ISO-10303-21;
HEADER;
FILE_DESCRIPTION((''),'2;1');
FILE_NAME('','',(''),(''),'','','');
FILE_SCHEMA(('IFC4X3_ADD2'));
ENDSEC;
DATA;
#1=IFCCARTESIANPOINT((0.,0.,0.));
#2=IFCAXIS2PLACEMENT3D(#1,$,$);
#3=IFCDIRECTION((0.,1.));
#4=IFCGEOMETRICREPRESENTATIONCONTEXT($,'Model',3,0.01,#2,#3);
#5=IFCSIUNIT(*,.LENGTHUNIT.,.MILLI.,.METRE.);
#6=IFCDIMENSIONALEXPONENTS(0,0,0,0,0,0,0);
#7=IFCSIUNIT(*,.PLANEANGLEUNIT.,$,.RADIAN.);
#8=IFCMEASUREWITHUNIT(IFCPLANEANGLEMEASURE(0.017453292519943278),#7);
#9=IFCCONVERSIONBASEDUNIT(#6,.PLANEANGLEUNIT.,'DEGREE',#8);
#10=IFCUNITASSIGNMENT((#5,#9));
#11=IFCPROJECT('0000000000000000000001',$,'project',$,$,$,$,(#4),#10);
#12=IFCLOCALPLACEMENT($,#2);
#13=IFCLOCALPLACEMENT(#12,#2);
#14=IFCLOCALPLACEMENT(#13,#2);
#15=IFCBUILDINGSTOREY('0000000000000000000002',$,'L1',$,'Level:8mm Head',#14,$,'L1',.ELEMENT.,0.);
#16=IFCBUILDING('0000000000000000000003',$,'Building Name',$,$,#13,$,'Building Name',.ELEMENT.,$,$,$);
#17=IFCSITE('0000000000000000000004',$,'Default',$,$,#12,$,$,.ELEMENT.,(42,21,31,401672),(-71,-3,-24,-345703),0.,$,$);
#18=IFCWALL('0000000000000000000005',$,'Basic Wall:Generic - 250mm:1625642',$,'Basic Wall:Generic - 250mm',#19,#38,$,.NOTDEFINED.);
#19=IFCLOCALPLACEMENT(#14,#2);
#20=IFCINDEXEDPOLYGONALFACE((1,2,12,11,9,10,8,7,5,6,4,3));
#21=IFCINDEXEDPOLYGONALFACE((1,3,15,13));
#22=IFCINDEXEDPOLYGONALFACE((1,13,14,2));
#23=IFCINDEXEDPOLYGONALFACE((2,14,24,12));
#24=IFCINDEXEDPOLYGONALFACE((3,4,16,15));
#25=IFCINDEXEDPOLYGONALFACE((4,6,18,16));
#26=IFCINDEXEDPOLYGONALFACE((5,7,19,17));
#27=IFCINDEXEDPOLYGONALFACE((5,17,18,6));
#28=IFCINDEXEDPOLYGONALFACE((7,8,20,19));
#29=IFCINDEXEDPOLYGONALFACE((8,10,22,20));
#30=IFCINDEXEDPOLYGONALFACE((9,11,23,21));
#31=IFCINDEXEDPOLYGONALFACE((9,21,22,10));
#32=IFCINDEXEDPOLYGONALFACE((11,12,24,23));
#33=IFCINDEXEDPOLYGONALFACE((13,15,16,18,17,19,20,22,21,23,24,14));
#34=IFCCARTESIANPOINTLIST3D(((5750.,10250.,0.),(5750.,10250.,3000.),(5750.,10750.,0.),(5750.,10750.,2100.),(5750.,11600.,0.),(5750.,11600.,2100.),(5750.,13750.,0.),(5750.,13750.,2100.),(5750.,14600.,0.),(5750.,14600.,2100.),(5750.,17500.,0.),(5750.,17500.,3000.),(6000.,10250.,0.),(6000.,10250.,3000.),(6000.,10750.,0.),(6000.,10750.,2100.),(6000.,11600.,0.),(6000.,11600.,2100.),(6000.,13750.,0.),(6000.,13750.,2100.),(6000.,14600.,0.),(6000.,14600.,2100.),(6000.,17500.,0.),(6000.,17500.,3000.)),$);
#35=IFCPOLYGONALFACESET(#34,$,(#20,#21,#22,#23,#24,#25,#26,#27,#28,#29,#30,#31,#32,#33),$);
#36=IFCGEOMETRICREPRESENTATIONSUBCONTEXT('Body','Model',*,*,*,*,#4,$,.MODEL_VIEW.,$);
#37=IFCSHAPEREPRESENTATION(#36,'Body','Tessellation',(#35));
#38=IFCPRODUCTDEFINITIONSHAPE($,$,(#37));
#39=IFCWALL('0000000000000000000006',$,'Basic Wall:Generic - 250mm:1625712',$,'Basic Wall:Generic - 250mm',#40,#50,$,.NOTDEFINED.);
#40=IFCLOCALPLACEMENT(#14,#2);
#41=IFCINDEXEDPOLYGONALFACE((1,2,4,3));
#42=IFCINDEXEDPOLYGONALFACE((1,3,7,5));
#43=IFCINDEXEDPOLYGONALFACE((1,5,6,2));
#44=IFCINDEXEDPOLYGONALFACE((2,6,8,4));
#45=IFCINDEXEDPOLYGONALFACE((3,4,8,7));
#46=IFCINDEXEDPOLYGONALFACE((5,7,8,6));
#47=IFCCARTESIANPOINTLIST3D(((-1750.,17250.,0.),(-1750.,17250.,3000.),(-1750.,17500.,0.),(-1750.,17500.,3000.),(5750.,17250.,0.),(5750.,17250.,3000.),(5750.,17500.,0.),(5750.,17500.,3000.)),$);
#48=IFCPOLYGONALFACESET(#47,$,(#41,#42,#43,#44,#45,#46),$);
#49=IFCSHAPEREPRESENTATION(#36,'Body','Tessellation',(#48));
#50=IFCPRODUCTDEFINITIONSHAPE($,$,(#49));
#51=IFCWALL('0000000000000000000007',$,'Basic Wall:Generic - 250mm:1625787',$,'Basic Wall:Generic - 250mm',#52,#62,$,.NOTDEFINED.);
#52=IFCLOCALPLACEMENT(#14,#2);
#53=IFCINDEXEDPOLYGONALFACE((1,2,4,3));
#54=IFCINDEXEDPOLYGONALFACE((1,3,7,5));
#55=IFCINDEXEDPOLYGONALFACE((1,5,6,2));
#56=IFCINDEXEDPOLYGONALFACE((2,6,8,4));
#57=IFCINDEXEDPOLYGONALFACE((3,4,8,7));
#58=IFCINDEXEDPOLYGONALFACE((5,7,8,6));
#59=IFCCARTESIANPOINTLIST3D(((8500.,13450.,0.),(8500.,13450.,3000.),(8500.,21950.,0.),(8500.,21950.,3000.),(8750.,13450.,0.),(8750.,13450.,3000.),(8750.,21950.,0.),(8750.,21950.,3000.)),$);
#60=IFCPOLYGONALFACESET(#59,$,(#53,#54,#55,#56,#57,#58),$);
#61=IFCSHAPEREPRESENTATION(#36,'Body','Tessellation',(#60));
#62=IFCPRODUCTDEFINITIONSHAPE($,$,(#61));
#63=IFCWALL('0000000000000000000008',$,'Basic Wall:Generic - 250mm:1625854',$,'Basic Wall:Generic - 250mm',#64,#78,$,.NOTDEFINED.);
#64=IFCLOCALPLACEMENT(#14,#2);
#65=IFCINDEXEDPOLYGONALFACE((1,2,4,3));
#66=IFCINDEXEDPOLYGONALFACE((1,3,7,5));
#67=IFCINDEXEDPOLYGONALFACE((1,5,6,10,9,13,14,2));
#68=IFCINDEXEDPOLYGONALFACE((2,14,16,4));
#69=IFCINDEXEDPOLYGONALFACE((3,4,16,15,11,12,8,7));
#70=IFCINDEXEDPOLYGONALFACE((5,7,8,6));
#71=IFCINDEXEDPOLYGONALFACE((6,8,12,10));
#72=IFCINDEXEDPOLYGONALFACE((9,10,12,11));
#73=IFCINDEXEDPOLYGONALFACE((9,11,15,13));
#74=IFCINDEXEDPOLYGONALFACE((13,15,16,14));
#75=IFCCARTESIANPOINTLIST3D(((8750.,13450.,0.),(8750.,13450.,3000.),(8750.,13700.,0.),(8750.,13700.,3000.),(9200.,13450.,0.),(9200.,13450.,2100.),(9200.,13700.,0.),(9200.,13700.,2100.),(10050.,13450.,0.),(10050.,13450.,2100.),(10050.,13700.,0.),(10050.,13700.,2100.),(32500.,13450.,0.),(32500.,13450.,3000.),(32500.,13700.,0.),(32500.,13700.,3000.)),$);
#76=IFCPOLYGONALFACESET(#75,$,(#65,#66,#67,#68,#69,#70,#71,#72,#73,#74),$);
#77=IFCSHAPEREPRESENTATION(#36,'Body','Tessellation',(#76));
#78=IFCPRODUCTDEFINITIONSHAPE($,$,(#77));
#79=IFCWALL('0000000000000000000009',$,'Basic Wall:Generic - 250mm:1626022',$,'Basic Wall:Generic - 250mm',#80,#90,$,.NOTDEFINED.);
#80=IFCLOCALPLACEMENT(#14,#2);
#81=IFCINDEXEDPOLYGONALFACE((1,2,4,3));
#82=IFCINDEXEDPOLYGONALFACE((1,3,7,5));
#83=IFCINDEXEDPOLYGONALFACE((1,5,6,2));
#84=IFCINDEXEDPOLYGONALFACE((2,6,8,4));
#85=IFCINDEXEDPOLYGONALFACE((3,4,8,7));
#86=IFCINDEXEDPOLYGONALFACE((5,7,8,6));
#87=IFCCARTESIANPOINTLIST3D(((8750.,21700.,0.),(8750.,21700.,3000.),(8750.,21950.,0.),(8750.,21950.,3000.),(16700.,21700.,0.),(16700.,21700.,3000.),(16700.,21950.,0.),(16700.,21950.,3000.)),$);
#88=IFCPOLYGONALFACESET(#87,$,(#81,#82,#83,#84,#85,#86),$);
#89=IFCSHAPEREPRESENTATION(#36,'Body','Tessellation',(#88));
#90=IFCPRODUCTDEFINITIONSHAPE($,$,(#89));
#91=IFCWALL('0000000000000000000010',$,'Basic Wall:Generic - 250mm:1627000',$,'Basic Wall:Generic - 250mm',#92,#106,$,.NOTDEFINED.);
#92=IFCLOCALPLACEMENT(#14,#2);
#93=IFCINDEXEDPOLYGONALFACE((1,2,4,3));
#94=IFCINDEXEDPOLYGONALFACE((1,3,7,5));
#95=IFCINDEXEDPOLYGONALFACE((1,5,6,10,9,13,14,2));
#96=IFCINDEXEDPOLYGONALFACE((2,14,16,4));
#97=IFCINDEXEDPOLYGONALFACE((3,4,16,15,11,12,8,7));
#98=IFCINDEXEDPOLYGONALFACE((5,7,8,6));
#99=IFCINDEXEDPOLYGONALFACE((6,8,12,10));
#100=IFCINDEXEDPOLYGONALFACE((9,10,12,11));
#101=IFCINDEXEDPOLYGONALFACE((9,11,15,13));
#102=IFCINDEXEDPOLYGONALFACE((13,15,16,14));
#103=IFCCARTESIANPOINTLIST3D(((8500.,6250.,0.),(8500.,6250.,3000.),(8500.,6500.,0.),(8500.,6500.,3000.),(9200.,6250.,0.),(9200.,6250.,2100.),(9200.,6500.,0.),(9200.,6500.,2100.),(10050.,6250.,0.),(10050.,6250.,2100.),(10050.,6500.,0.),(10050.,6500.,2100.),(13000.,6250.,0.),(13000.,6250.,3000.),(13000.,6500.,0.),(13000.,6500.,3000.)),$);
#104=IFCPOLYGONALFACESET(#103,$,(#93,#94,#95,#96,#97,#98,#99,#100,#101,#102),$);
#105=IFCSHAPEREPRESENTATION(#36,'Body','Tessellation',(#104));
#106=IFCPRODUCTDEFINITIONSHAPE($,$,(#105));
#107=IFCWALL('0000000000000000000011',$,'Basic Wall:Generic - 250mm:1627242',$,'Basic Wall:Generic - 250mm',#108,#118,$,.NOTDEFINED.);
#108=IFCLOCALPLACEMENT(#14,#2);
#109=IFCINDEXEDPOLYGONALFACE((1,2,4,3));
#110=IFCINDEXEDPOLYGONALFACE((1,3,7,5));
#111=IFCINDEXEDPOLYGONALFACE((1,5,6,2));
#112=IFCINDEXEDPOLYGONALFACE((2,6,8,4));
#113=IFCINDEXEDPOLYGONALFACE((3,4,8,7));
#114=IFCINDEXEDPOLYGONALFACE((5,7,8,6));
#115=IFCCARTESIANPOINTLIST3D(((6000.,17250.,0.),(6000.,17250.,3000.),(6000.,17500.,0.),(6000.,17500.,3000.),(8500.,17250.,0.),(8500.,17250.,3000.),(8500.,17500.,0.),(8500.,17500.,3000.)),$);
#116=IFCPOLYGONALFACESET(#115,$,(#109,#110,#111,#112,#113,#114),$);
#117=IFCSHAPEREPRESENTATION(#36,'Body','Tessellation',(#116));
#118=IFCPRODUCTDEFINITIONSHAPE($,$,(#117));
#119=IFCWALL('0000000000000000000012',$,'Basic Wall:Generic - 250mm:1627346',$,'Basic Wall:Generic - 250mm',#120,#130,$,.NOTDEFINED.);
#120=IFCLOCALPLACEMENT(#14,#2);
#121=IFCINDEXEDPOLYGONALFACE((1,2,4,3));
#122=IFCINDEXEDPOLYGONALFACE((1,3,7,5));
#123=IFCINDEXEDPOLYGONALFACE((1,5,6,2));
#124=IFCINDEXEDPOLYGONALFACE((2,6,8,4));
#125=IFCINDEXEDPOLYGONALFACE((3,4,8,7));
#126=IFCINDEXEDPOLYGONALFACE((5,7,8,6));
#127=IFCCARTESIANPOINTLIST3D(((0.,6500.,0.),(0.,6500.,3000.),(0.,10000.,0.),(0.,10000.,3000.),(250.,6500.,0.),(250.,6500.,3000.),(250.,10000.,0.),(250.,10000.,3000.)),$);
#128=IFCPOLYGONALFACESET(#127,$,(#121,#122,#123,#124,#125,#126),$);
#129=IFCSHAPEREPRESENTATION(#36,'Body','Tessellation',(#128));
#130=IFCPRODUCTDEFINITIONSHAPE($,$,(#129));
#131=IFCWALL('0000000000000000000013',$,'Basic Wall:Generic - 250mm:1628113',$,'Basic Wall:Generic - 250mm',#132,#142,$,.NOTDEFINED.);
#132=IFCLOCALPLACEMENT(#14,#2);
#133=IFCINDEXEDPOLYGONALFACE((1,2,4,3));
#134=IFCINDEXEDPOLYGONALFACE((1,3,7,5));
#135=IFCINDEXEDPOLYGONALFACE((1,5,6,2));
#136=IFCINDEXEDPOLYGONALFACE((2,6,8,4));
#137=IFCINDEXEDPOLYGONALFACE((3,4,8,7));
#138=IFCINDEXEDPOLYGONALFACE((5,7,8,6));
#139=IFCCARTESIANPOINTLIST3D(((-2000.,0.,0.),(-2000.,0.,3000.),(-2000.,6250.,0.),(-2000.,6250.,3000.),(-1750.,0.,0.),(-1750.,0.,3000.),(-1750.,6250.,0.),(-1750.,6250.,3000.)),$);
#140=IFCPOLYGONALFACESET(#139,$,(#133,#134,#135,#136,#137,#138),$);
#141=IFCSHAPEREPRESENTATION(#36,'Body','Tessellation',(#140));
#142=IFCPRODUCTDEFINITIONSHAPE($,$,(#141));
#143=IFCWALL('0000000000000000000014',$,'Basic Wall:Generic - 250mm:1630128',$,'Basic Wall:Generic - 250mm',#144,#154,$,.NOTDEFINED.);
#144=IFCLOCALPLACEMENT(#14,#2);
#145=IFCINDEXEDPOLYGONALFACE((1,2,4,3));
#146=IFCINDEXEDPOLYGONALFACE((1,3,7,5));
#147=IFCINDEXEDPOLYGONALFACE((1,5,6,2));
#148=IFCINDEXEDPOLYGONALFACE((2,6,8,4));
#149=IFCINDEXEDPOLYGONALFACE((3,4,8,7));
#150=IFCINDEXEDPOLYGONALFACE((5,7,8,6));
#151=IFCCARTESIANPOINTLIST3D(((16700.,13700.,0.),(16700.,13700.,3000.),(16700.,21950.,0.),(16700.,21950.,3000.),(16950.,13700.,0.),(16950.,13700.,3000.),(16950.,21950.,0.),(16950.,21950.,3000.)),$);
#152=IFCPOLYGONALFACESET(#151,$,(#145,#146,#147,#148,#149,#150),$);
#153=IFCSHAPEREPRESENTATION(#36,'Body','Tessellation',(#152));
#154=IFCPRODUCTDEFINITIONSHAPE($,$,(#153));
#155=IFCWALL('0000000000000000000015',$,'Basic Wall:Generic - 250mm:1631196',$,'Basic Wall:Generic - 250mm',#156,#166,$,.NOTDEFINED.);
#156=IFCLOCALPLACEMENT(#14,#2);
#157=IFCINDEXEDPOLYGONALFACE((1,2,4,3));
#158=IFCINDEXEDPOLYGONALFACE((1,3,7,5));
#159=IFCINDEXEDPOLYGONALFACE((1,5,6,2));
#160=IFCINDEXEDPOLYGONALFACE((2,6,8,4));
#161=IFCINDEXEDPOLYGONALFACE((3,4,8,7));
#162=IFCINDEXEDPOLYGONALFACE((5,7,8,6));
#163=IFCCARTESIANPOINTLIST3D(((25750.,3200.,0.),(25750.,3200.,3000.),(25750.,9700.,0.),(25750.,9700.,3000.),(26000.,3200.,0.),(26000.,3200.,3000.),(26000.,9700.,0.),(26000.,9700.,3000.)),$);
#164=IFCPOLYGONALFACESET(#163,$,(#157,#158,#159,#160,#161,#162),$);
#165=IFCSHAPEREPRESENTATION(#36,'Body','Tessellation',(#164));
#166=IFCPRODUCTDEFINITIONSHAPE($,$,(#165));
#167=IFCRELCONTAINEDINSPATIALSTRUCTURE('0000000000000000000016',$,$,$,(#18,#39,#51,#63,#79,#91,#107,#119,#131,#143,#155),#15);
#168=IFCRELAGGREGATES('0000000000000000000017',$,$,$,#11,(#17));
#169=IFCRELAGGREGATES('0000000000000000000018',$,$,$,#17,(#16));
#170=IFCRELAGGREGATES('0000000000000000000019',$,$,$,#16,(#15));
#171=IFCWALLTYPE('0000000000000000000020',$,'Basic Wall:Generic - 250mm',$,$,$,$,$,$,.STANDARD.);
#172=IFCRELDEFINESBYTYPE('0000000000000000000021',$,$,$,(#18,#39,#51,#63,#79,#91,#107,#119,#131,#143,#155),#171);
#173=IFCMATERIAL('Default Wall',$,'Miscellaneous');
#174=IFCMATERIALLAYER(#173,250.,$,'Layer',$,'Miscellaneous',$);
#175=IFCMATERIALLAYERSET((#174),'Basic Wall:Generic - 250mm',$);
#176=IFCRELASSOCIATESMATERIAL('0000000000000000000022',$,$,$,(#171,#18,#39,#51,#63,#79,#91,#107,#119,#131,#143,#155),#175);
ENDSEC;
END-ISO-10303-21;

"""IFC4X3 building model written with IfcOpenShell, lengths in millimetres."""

from ifc_helpers import new_model, entity, si_unit, converted_unit, direction, frame, frame_2d, origin, place, context, subcontext, project, spatial, rectangle, extrude, material, layer, layer_set, type_object, element, save


model = new_model("IFC4X3")

# Units and contexts
model_context = context("Model", 3, precision=0.01, world=origin(), true_north=direction((0.0, 1.0)))
body_context = subcontext(model_context, "Body", "Model", "MODEL_VIEW")
ifc_project = project(units=[si_unit("LENGTHUNIT", "METRE", prefix="MILLI"), converted_unit("PLANEANGLEUNIT", "DEGREE", entity("IfcPlaneAngleMeasure", 0.017453292519943278), si_unit("PLANEANGLEUNIT", "RADIAN"), dimensions=[0, 0, 0, 0, 0, 0, 0])], contexts=[model_context])

# Site, building, storey
site_placement = place(None, origin())
site = spatial("IfcSite", under=ifc_project, at=site_placement, Name="Default", CompositionType="ELEMENT", RefLatitude=(42, 21, 31, 401672), RefLongitude=(-71, -3, -24, -345703), RefElevation=0.0)
building_placement = place(site_placement, origin())
building = spatial("IfcBuilding", under=site, at=building_placement, Name="Building Name", LongName="Building Name", CompositionType="ELEMENT")
storey_placement = place(building_placement, origin())
storey = spatial("IfcBuildingStorey", under=building, at=storey_placement, Name="L1", ObjectType="Level:8mm Head", LongName="L1", CompositionType="ELEMENT", Elevation=0.0)

# Shared definitions
ifc_material = material(Name="Default Wall", Category="Miscellaneous")
ifc_layer = layer(ifc_material, 250.0, Name="Layer", Category="Miscellaneous")
ifc_layer_set = layer_set([ifc_layer], Name="Basic Wall:Generic - 250mm")
wall_type = type_object("IfcWallType", Name="Basic Wall:Generic - 250mm", PredefinedType="STANDARD", material=ifc_layer_set)

# Wall, openings
wall_1_placement = place(storey_placement, frame((5875.0, 10250.0, 0.0), z_axis=(0.0, 0.0, 1.0), x_axis=(0.0, 1.0, 0.0)))
wall_1 = element("IfcWall", 1, at=wall_1_placement, inside=storey, type_object=wall_type, material=ifc_layer_set, Name="Basic Wall:Generic - 250mm:1625642", ObjectType="Basic Wall:Generic - 250mm", PredefinedType="NOTDEFINED", context=body_context, shape_type="SweptSolid", body=[
    extrude(rectangle(XDim=7250.0, YDim=250.0, at=frame_2d((3625.0, 0.0), x_axis=(1.0, 0.0))), origin(), (0.0, 0.0, 1.0), 3000.0),
])
opening_1_placement = place(wall_1_placement, frame((500.0, -125.0, 0.0)))
element("IfcOpeningElement", 2, at=opening_1_placement, cuts=wall_1, PredefinedType="OPENING", context=body_context, shape_type="SweptSolid", body=[
    extrude(rectangle(XDim=2100.0, YDim=850.0, at=frame_2d((1050.0, 425.0), x_axis=(1.0, 0.0))), frame((0.0, 0.0, 0.0), z_axis=(0.0, 1.0, 0.0), x_axis=(0.0, 0.0, 1.0)), (0.0, 0.0, 1.0), 250.0),
])
opening_2_placement = place(wall_1_placement, frame((4350.0, 125.0, 0.0)))
element("IfcOpeningElement", 3, at=opening_2_placement, cuts=wall_1, PredefinedType="OPENING", context=body_context, shape_type="SweptSolid", body=[
    extrude(rectangle(XDim=2100.0, YDim=850.0, at=frame_2d((1050.0, 425.0), x_axis=(1.0, 0.0))), frame((0.0, 0.0, 0.0), z_axis=(0.0, -1.0, 0.0), x_axis=(0.0, 0.0, 1.0)), (0.0, 0.0, 1.0), 250.0),
])

# Walls
wall_2_placement = place(storey_placement, frame((5750.0, 17375.0, 0.0), z_axis=(0.0, 0.0, 1.0), x_axis=(-1.0, 0.0, 0.0)))
element("IfcWall", 4, at=wall_2_placement, inside=storey, type_object=wall_type, material=ifc_layer_set, Name="Basic Wall:Generic - 250mm:1625712", ObjectType="Basic Wall:Generic - 250mm", PredefinedType="NOTDEFINED", context=body_context, shape_type="SweptSolid", body=[
    extrude(rectangle(XDim=7500.0, YDim=250.0, at=frame_2d((3750.0, 0.0), x_axis=(-1.0, 0.0))), origin(), (0.0, 0.0, 1.0), 3000.0),
])
wall_3_placement = place(storey_placement, frame((8625.0, 21950.0, 0.0), z_axis=(0.0, 0.0, 1.0), x_axis=(0.0, -1.0, 0.0)))
element("IfcWall", 5, at=wall_3_placement, inside=storey, type_object=wall_type, material=ifc_layer_set, Name="Basic Wall:Generic - 250mm:1625787", ObjectType="Basic Wall:Generic - 250mm", PredefinedType="NOTDEFINED", context=body_context, shape_type="SweptSolid", body=[
    extrude(rectangle(XDim=8500.0, YDim=250.0, at=frame_2d((4250.0, 0.0), x_axis=(-1.0, 0.0))), origin(), (0.0, 0.0, 1.0), 3000.0),
])

# Wall, opening
wall_4_placement = place(storey_placement, frame((8750.0, 13575.0, 0.0)))
wall_4 = element("IfcWall", 6, at=wall_4_placement, inside=storey, type_object=wall_type, material=ifc_layer_set, Name="Basic Wall:Generic - 250mm:1625854", ObjectType="Basic Wall:Generic - 250mm", PredefinedType="NOTDEFINED", context=body_context, shape_type="SweptSolid", body=[
    extrude(rectangle(XDim=23750.0, YDim=250.0, at=frame_2d((11875.0, 0.0), x_axis=(-1.0, 0.0))), origin(), (0.0, 0.0, 1.0), 3000.0),
])
opening_3_placement = place(wall_4_placement, frame((450.0, -125.0, 0.0)))
element("IfcOpeningElement", 7, at=opening_3_placement, cuts=wall_4, PredefinedType="OPENING", context=body_context, shape_type="SweptSolid", body=[
    extrude(rectangle(XDim=2100.0, YDim=850.0, at=frame_2d((1050.0, 425.0), x_axis=(1.0, 0.0))), frame((0.0, 0.0, 0.0), z_axis=(0.0, 1.0, 0.0), x_axis=(0.0, 0.0, 1.0)), (0.0, 0.0, 1.0), 250.0),
])

# Wall
wall_5_placement = place(storey_placement, frame((16700.0, 21825.0, 0.0), z_axis=(0.0, 0.0, 1.0), x_axis=(-1.0, 0.0, 0.0)))
element("IfcWall", 8, at=wall_5_placement, inside=storey, type_object=wall_type, material=ifc_layer_set, Name="Basic Wall:Generic - 250mm:1626022", ObjectType="Basic Wall:Generic - 250mm", PredefinedType="NOTDEFINED", context=body_context, shape_type="SweptSolid", body=[
    extrude(rectangle(XDim=7950.0, YDim=250.0, at=frame_2d((3975.0, 0.0), x_axis=(-1.0, 0.0))), origin(), (0.0, 0.0, 1.0), 3000.0),
])

# Wall, opening
wall_6_placement = place(storey_placement, frame((13000.0, 6375.0, 0.0), z_axis=(0.0, 0.0, 1.0), x_axis=(-1.0, 0.0, 0.0)))
wall_6 = element("IfcWall", 9, at=wall_6_placement, inside=storey, type_object=wall_type, material=ifc_layer_set, Name="Basic Wall:Generic - 250mm:1627000", ObjectType="Basic Wall:Generic - 250mm", PredefinedType="NOTDEFINED", context=body_context, shape_type="SweptSolid", body=[
    extrude(rectangle(XDim=4500.0, YDim=250.0, at=frame_2d((2250.0, 0.0), x_axis=(-1.0, 0.0))), origin(), (0.0, 0.0, 1.0), 3000.0),
])
opening_4_placement = place(wall_6_placement, frame((3800.0, 125.0, 0.0)))
element("IfcOpeningElement", 10, at=opening_4_placement, cuts=wall_6, PredefinedType="OPENING", context=body_context, shape_type="SweptSolid", body=[
    extrude(rectangle(XDim=2100.0, YDim=850.0, at=frame_2d((1050.0, 425.0), x_axis=(1.0, 0.0))), frame((0.0, 0.0, 0.0), z_axis=(0.0, -1.0, 0.0), x_axis=(0.0, 0.0, 1.0)), (0.0, 0.0, 1.0), 250.0),
])

# Walls
wall_7_placement = place(storey_placement, frame((6000.0, 17375.0, 0.0)))
element("IfcWall", 11, at=wall_7_placement, inside=storey, type_object=wall_type, material=ifc_layer_set, Name="Basic Wall:Generic - 250mm:1627242", ObjectType="Basic Wall:Generic - 250mm", PredefinedType="NOTDEFINED", context=body_context, shape_type="SweptSolid", body=[
    extrude(rectangle(XDim=2500.0, YDim=250.0, at=frame_2d((1250.0, 0.0), x_axis=(-1.0, 0.0))), origin(), (0.0, 0.0, 1.0), 3000.0),
])
wall_8_placement = place(storey_placement, frame((125.0, 6500.0, 0.0), z_axis=(0.0, 0.0, 1.0), x_axis=(0.0, 1.0, 0.0)))
element("IfcWall", 12, at=wall_8_placement, inside=storey, type_object=wall_type, material=ifc_layer_set, Name="Basic Wall:Generic - 250mm:1627346", ObjectType="Basic Wall:Generic - 250mm", PredefinedType="NOTDEFINED", context=body_context, shape_type="SweptSolid", body=[
    extrude(rectangle(XDim=3500.0, YDim=250.0, at=frame_2d((1750.0, 0.0), x_axis=(-1.0, 0.0))), origin(), (0.0, 0.0, 1.0), 3000.0),
])
wall_9_placement = place(storey_placement, frame((-1875.0, 6250.0, 0.0), z_axis=(0.0, 0.0, 1.0), x_axis=(0.0, -1.0, 0.0)))
element("IfcWall", 13, at=wall_9_placement, inside=storey, type_object=wall_type, material=ifc_layer_set, Name="Basic Wall:Generic - 250mm:1628113", ObjectType="Basic Wall:Generic - 250mm", PredefinedType="NOTDEFINED", context=body_context, shape_type="SweptSolid", body=[
    extrude(rectangle(XDim=6250.0, YDim=250.0, at=frame_2d((3125.0, 0.0), x_axis=(-1.0, 0.0))), origin(), (0.0, 0.0, 1.0), 3000.0),
])
wall_10_placement = place(storey_placement, frame((16825.0, 13700.0, 0.0), z_axis=(0.0, 0.0, 1.0), x_axis=(0.0, 1.0, 0.0)))
element("IfcWall", 14, at=wall_10_placement, inside=storey, type_object=wall_type, material=ifc_layer_set, Name="Basic Wall:Generic - 250mm:1630128", ObjectType="Basic Wall:Generic - 250mm", PredefinedType="NOTDEFINED", context=body_context, shape_type="SweptSolid", body=[
    extrude(rectangle(XDim=8250.0, YDim=250.0, at=frame_2d((4125.0, 0.0), x_axis=(-1.0, 0.0))), origin(), (0.0, 0.0, 1.0), 3000.0),
])
wall_11_placement = place(storey_placement, frame((25875.0, 3200.0, 0.0), z_axis=(0.0, 0.0, 1.0), x_axis=(0.0, 1.0, 0.0)))
element("IfcWall", 15, at=wall_11_placement, inside=storey, type_object=wall_type, material=ifc_layer_set, Name="Basic Wall:Generic - 250mm:1631196", ObjectType="Basic Wall:Generic - 250mm", PredefinedType="NOTDEFINED", context=body_context, shape_type="SweptSolid", body=[
    extrude(rectangle(XDim=6500.0, YDim=250.0, at=frame_2d((3250.0, 0.0), x_axis=(-1.0, 0.0))), origin(), (0.0, 0.0, 1.0), 3000.0),
])

save(model, "model.ifc")
